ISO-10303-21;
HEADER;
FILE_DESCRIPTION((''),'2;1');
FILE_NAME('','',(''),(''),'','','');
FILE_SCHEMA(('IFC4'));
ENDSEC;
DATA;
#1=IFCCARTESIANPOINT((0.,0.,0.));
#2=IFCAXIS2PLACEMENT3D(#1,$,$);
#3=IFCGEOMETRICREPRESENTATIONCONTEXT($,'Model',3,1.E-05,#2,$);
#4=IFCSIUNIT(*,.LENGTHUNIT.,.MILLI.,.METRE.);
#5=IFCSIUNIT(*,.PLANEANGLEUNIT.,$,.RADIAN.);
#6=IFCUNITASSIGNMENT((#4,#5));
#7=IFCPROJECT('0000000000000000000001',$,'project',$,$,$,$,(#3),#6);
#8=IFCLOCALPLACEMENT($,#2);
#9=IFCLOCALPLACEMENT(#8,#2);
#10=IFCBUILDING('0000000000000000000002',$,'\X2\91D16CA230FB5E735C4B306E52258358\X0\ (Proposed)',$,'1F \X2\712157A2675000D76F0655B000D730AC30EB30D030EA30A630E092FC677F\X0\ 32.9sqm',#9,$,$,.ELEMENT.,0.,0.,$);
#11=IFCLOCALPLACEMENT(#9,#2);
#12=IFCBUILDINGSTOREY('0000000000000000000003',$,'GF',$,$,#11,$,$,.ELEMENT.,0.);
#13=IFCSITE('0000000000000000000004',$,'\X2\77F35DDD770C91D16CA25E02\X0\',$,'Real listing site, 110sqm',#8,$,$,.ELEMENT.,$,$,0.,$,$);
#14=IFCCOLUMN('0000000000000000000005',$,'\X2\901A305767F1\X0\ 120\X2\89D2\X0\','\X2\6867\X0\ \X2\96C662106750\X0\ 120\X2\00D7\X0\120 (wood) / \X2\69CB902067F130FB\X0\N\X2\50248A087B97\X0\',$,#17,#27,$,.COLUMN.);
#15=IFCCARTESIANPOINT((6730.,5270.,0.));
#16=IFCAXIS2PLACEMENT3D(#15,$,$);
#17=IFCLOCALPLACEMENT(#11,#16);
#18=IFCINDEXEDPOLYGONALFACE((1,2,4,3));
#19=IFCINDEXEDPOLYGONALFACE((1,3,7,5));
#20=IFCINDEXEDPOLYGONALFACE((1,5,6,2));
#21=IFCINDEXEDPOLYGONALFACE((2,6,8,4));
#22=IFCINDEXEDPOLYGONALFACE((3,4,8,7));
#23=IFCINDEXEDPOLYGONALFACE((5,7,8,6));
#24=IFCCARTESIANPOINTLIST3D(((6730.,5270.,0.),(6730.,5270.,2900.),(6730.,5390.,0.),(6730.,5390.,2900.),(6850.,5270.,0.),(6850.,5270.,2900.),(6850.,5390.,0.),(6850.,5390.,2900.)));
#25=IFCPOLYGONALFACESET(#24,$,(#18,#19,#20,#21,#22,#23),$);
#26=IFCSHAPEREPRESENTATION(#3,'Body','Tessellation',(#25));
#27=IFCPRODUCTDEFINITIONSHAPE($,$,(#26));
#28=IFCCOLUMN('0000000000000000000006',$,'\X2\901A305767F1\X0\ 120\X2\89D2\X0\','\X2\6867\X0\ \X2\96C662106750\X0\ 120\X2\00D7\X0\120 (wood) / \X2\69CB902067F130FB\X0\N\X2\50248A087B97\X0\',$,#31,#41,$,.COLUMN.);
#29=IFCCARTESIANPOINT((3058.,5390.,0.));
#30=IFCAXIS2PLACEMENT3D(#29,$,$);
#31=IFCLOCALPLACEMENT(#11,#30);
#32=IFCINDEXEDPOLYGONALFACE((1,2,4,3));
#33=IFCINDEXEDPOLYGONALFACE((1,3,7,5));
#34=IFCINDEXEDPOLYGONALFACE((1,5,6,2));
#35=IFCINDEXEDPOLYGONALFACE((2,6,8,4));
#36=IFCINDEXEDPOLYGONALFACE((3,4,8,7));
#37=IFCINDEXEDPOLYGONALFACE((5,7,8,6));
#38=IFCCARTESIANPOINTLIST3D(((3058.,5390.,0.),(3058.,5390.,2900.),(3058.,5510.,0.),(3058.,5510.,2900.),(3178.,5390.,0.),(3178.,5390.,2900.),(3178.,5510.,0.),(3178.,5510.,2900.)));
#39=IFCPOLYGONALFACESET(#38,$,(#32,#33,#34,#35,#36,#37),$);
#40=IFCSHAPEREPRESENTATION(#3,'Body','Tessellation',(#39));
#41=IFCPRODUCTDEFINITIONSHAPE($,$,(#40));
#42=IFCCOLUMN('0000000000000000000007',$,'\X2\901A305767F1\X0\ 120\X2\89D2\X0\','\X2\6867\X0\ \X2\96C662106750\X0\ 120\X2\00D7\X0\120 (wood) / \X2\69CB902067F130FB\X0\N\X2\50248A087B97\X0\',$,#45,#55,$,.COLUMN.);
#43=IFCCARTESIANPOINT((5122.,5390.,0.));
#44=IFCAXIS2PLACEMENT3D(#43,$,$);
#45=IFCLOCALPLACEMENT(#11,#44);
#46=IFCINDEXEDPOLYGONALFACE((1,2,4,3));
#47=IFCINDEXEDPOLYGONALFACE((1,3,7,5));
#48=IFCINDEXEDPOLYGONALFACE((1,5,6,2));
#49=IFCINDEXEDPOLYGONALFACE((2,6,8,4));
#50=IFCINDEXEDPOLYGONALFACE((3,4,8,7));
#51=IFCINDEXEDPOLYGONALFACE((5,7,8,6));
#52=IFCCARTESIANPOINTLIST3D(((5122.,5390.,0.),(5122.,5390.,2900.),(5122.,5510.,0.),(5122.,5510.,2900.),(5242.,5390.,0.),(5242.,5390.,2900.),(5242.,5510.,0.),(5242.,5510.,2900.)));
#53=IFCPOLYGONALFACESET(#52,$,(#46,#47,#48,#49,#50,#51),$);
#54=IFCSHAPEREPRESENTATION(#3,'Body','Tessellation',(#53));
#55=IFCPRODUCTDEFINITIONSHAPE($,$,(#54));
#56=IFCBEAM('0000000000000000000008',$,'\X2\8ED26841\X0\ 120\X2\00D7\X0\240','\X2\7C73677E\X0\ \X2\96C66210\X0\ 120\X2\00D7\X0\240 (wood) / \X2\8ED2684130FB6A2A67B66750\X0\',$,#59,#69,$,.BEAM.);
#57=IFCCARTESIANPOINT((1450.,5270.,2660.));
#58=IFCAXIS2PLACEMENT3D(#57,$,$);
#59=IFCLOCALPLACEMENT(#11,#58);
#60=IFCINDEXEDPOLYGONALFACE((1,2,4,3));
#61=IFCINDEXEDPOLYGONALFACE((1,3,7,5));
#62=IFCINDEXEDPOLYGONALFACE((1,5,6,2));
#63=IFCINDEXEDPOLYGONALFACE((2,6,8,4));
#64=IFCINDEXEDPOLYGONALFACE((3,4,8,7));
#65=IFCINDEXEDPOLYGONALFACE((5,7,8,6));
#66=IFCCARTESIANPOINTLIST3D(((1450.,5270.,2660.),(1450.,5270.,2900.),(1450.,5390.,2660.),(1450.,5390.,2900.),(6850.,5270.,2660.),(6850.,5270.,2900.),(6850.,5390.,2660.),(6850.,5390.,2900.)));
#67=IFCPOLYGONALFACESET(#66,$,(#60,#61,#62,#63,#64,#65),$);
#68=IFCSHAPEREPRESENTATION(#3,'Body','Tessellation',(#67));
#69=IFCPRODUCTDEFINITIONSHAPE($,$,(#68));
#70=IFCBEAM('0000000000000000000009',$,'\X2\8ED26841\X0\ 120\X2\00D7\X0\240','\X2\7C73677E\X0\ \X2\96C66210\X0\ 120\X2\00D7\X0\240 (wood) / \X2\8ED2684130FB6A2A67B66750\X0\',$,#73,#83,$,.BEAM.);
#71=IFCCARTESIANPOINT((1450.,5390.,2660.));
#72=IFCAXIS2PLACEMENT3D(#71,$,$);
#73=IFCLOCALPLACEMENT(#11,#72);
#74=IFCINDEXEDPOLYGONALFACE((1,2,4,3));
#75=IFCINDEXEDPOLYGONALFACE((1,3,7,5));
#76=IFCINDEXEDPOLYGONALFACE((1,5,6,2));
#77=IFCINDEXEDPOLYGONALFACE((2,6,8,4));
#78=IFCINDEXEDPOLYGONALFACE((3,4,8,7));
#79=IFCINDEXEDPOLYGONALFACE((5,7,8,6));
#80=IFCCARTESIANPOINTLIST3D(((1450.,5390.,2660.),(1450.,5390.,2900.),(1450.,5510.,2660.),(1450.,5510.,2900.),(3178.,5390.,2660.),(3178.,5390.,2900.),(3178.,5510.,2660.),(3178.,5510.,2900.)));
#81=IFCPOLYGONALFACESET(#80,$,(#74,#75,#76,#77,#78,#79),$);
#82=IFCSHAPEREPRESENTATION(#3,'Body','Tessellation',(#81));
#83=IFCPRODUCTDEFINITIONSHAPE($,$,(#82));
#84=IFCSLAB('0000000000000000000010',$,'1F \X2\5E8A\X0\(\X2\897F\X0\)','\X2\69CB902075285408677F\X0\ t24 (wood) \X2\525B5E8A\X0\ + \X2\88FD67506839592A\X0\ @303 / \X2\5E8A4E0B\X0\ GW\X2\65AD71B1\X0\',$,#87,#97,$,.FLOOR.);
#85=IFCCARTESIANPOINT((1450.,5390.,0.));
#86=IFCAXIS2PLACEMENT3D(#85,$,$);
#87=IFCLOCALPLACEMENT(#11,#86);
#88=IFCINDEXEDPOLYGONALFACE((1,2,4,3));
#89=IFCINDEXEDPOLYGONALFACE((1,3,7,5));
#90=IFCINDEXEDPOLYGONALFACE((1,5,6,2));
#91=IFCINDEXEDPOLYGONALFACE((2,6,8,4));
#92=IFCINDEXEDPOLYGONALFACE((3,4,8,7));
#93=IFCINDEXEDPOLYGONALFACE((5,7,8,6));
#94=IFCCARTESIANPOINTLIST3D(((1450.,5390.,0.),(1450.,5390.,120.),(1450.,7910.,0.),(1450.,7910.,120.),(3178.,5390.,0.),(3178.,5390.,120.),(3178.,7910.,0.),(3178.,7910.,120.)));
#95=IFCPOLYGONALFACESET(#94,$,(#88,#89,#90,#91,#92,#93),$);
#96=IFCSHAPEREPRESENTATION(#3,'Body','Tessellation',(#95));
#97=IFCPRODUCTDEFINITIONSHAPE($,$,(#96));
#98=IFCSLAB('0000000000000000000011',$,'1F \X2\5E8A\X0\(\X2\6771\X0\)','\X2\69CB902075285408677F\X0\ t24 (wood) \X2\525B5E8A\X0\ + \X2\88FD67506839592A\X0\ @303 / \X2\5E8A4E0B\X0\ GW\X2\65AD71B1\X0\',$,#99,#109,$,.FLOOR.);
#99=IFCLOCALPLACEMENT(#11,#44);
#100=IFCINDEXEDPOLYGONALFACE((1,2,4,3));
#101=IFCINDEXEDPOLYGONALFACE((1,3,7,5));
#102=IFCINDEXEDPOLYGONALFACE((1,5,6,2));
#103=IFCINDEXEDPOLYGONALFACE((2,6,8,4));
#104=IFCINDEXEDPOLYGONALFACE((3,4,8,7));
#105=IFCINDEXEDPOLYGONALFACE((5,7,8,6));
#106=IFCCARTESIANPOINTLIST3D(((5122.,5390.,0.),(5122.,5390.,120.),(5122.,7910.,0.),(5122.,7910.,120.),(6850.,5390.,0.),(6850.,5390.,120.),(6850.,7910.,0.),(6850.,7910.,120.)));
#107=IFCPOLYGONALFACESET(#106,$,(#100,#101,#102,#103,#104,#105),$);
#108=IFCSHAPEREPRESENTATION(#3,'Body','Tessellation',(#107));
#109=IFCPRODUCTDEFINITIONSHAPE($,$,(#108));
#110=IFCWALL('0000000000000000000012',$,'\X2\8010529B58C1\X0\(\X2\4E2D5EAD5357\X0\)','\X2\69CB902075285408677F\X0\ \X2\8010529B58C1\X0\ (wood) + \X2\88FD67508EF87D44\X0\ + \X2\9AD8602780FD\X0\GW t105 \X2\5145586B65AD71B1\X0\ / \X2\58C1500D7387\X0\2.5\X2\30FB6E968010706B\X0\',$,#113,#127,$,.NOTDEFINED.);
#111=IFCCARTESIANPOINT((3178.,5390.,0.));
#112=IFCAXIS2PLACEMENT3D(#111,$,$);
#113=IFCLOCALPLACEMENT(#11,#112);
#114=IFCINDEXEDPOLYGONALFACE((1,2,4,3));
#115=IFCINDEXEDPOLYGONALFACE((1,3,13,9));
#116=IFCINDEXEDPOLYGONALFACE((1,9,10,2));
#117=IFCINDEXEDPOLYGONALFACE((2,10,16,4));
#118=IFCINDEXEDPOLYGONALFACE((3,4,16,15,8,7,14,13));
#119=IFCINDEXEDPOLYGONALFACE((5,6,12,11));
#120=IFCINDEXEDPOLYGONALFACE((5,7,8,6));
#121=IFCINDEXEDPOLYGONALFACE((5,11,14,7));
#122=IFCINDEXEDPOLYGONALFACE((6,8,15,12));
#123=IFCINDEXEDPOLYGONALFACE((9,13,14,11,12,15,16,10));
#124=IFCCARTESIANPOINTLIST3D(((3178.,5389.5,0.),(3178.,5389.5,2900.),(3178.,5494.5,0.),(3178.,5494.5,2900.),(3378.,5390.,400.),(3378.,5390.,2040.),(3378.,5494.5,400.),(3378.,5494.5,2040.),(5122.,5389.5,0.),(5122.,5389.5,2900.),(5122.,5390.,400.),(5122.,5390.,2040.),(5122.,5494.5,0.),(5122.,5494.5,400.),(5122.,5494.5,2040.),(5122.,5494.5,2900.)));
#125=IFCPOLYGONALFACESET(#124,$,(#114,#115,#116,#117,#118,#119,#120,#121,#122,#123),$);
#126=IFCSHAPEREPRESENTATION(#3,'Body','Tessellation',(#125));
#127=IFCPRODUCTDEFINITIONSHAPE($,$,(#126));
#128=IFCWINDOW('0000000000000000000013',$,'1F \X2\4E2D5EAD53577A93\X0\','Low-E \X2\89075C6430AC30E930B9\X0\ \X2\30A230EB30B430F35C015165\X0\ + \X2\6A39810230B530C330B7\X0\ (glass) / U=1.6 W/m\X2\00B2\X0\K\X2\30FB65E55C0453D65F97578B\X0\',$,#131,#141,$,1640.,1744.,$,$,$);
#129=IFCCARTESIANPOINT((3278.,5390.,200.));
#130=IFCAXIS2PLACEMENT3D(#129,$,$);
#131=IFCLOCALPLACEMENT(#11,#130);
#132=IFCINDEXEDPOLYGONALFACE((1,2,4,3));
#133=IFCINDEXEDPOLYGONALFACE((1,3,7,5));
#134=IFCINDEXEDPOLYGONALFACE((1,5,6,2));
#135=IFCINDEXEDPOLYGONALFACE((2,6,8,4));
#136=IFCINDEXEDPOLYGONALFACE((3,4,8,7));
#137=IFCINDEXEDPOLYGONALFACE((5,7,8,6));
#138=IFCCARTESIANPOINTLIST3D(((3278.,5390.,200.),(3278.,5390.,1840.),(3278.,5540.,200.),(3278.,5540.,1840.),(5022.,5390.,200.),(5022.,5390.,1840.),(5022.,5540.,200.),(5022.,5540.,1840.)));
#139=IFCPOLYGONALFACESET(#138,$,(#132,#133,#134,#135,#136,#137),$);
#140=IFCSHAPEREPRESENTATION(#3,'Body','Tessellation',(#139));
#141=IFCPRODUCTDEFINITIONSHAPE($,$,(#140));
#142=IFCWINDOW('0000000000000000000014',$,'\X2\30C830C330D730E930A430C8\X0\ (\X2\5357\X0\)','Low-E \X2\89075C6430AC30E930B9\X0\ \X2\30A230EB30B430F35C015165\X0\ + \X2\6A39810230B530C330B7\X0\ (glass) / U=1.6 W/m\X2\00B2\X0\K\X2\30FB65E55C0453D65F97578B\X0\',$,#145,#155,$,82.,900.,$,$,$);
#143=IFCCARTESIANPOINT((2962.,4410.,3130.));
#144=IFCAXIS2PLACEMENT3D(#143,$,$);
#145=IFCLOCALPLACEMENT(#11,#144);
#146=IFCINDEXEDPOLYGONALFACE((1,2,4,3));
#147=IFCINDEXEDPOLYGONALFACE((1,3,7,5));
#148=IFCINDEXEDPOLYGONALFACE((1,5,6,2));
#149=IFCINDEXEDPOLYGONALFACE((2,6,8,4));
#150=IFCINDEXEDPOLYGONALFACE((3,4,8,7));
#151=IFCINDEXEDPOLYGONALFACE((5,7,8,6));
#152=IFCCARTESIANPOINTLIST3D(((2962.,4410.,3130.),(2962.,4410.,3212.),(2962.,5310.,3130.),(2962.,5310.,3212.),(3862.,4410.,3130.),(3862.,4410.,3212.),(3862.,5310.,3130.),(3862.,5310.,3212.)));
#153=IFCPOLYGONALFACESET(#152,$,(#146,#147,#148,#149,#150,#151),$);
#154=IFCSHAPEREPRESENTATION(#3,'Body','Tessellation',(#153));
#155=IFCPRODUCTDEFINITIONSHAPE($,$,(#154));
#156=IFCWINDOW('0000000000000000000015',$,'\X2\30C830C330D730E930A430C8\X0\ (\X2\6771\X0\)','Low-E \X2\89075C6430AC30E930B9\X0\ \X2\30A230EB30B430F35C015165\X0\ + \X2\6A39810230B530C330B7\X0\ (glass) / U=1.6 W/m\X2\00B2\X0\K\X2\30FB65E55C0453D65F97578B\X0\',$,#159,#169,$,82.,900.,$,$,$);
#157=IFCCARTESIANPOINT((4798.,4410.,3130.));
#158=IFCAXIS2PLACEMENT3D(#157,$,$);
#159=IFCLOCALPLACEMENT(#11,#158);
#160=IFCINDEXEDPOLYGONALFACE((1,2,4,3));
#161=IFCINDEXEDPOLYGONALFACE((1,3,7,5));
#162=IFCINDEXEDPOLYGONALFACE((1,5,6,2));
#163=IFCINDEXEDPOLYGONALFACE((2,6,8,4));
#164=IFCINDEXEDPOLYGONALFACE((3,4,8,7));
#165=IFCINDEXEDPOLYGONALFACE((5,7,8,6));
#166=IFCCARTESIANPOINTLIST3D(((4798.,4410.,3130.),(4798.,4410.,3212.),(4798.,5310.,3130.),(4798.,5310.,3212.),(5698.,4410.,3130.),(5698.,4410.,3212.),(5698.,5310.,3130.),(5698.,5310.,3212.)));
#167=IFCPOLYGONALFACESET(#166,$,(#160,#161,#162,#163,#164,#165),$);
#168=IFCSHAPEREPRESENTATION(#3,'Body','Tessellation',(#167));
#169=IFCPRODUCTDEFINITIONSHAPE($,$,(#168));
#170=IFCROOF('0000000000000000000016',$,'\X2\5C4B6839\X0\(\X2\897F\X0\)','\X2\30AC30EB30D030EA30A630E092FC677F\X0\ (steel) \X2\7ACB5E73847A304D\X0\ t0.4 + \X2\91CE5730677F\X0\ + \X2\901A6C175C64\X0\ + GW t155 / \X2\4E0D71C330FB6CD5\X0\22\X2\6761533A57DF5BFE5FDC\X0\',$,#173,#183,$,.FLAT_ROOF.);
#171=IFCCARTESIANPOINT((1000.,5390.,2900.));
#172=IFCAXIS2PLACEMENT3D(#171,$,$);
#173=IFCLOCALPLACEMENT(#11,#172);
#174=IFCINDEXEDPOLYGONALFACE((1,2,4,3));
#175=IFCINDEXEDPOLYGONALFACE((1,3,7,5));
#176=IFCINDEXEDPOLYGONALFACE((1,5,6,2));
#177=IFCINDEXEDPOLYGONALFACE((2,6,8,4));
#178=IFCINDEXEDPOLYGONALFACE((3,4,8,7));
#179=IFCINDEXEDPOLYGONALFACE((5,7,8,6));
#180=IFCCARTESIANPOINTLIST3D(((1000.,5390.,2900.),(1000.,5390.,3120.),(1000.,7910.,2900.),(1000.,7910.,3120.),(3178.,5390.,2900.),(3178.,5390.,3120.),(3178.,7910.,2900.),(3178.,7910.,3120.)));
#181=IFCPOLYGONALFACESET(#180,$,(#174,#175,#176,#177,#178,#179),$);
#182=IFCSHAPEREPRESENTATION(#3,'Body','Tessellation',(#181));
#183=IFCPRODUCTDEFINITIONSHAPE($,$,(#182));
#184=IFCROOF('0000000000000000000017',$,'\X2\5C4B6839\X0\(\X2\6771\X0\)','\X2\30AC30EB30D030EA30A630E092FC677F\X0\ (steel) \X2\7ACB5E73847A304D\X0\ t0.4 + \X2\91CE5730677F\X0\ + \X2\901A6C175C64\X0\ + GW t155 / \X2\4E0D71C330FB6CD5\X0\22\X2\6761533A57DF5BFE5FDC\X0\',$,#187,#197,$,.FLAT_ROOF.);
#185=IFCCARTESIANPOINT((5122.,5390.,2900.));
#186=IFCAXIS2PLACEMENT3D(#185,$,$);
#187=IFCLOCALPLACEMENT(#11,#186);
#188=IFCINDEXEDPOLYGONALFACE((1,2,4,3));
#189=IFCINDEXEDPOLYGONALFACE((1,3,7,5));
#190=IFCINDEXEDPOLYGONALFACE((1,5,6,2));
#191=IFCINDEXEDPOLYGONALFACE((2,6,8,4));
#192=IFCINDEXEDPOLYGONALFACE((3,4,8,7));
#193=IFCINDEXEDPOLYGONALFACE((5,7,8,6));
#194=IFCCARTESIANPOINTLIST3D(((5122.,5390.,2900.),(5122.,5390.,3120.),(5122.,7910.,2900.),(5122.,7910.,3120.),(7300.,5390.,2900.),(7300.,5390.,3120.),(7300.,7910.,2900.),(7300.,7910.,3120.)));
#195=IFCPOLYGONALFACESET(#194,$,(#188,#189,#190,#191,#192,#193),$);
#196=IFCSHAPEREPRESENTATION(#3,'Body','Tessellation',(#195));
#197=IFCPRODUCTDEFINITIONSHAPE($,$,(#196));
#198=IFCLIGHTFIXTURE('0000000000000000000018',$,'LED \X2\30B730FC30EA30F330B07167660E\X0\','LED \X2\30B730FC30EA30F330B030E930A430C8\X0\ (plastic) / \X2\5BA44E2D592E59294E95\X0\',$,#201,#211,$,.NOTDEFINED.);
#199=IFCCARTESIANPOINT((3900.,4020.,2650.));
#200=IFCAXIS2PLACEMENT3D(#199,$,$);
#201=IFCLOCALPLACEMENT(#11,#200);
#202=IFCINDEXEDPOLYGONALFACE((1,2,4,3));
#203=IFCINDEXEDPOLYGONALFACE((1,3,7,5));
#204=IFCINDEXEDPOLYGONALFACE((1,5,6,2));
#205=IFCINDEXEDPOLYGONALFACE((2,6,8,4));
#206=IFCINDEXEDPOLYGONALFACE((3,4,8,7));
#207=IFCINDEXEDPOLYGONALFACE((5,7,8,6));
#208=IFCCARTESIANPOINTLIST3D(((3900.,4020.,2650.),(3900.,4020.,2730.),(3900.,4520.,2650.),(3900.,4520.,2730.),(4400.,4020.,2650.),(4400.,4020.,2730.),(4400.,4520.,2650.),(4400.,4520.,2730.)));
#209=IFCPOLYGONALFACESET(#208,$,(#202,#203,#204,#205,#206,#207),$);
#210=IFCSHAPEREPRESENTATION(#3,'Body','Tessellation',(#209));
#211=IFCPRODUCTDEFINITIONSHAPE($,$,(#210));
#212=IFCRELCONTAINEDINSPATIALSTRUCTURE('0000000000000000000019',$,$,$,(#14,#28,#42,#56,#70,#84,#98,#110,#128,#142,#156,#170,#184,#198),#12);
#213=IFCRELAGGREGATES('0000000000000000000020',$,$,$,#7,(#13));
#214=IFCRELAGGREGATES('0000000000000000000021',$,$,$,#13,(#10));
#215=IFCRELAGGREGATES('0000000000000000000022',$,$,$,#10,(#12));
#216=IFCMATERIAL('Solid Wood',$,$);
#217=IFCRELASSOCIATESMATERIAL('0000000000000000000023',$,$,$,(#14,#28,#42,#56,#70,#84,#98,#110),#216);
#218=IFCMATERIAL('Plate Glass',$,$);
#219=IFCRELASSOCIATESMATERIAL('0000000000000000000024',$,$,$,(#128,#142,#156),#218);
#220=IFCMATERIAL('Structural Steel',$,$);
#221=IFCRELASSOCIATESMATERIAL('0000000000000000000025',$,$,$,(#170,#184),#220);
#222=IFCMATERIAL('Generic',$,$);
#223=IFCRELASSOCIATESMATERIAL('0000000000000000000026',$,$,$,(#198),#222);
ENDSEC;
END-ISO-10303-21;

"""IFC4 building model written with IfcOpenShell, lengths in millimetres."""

from ifc_helpers import new_model, si_unit, frame, frame_2d, origin, place, context, project, spatial, rectangle, extrude, material, element, fill, save


model = new_model("IFC4")

# Units and contexts
model_context = context("Model", 3, precision=1e-05, world=origin())
ifc_project = project(units=[si_unit("LENGTHUNIT", "METRE", prefix="MILLI"), si_unit("PLANEANGLEUNIT", "RADIAN")], contexts=[model_context])

# Site, building, storey
site_placement = place(None, origin())
site = spatial("IfcSite", under=ifc_project, at=site_placement, Name="石川県金沢市", ObjectType="Real listing site, 110sqm", CompositionType="ELEMENT", RefElevation=0.0)
building_placement = place(site_placement, origin())
building = spatial("IfcBuilding", under=site, at=building_placement, Name="金沢・平屋の別荘 (Proposed)", ObjectType="1F 無垢材×漆喰×ガルバリウム鋼板 32.9sqm", CompositionType="ELEMENT", ElevationOfRefHeight=0.0, ElevationOfTerrain=0.0)
storey_placement = place(building_placement, origin())
storey = spatial("IfcBuildingStorey", under=building, at=storey_placement, Name="GF", CompositionType="ELEMENT", Elevation=0.0)

# Columns
ifc_material_1 = material(Name="Solid Wood")
column_1_placement = place(storey_placement, frame((6730.0, 5270.0, 0.0)))
element("IfcColumn", 1, at=column_1_placement, inside=storey, material=ifc_material_1, Name="通し柱 120角", Description="桧 集成材 120×120 (wood) / 構造柱・N値計算", PredefinedType="COLUMN", context=model_context, shape_type="SweptSolid", body=[
    extrude(rectangle(XDim=120.0, YDim=120.0, at=frame_2d((60.0, 60.0))), frame((6730.0, 5270.0, 0.0)), (0.0, 0.0, 1.0), 2900.0),
])
column_2_placement = place(storey_placement, frame((3058.0, 5390.0, 0.0)))
element("IfcColumn", 2, at=column_2_placement, inside=storey, material=ifc_material_1, Name="通し柱 120角", Description="桧 集成材 120×120 (wood) / 構造柱・N値計算", PredefinedType="COLUMN", context=model_context, shape_type="SweptSolid", body=[
    extrude(rectangle(XDim=120.0, YDim=120.0, at=frame_2d((60.0, 60.0))), frame((3058.0, 5390.0, 0.0)), (0.0, 0.0, 1.0), 2900.0),
])
column_3_placement = place(storey_placement, frame((5122.0, 5390.0, 0.0)))
element("IfcColumn", 3, at=column_3_placement, inside=storey, material=ifc_material_1, Name="通し柱 120角", Description="桧 集成材 120×120 (wood) / 構造柱・N値計算", PredefinedType="COLUMN", context=model_context, shape_type="SweptSolid", body=[
    extrude(rectangle(XDim=120.0, YDim=120.0, at=frame_2d((60.0, 60.0))), frame((5122.0, 5390.0, 0.0)), (0.0, 0.0, 1.0), 2900.0),
])

# Beams
beam_1_placement = place(storey_placement, frame((1450.0, 5270.0, 2660.0)))
element("IfcBeam", 4, at=beam_1_placement, inside=storey, material=ifc_material_1, Name="軒桁 120×240", Description="米松 集成 120×240 (wood) / 軒桁・横架材", PredefinedType="BEAM", context=model_context, shape_type="SweptSolid", body=[
    extrude(rectangle(XDim=5400.0, YDim=120.0, at=frame_2d((2700.0, 60.0))), frame((1450.0, 5270.0, 2660.0)), (0.0, 0.0, 1.0), 240.0),
])
beam_2_placement = place(storey_placement, frame((1450.0, 5390.0, 2660.0)))
element("IfcBeam", 5, at=beam_2_placement, inside=storey, material=ifc_material_1, Name="軒桁 120×240", Description="米松 集成 120×240 (wood) / 軒桁・横架材", PredefinedType="BEAM", context=model_context, shape_type="SweptSolid", body=[
    extrude(rectangle(XDim=1728.0, YDim=120.0, at=frame_2d((864.0, 60.0))), frame((1450.0, 5390.0, 2660.0)), (0.0, 0.0, 1.0), 240.0),
])

# Slabs
slab_1_placement = place(storey_placement, frame((1450.0, 5390.0, 0.0)))
element("IfcSlab", 6, at=slab_1_placement, inside=storey, material=ifc_material_1, Name="1F 床(西)", Description="構造用合板 t24 (wood) 剛床 + 製材根太 @303 / 床下 GW断熱", PredefinedType="FLOOR", context=model_context, shape_type="SweptSolid", body=[
    extrude(rectangle(XDim=1728.0, YDim=2520.0, at=frame_2d((864.0, 1260.0))), frame((1450.0, 5390.0, 0.0)), (0.0, 0.0, 1.0), 120.0),
])
slab_2_placement = place(storey_placement, frame((5122.0, 5390.0, 0.0)))
element("IfcSlab", 7, at=slab_2_placement, inside=storey, material=ifc_material_1, Name="1F 床(東)", Description="構造用合板 t24 (wood) 剛床 + 製材根太 @303 / 床下 GW断熱", PredefinedType="FLOOR", context=model_context, shape_type="SweptSolid", body=[
    extrude(rectangle(XDim=1728.0, YDim=2520.0, at=frame_2d((864.0, 1260.0))), frame((5122.0, 5390.0, 0.0)), (0.0, 0.0, 1.0), 120.0),
])

# Wall, opening, window
wall_1_placement = place(storey_placement, frame((3178.0, 5390.0, 0.0)))
wall_1 = element("IfcWall", 8, at=wall_1_placement, inside=storey, material=ifc_material_1, Name="耐力壁(中庭南)", Description="構造用合板 耐力壁 (wood) + 製材軸組 + 高性能GW t105 充填断熱 / 壁倍率2.5・準耐火", PredefinedType="NOTDEFINED", context=model_context, shape_type="SweptSolid", body=[
    extrude(rectangle(XDim=1944.0, YDim=105.0, at=frame_2d((972.0, 52.0))), frame((3178.0, 5390.0, 0.0)), (0.0, 0.0, 1.0), 2900.0),
])
opening_placement = place(storey_placement, frame((3278.0, 5390.0, 200.0)))
opening = element("IfcOpeningElement", 9, at=opening_placement, cuts=wall_1, PredefinedType="NOTDEFINED", context=model_context, shape_type="SweptSolid", body=[
    extrude(rectangle(XDim=1744.0, YDim=150.0, at=frame_2d((872.0, 75.0))), frame((3278.0, 5390.0, 200.0)), (0.0, 0.0, 1.0), 1640.0),
])
ifc_material_2 = material(Name="Plate Glass")
window_1_placement = place(storey_placement, frame((3278.0, 5390.0, 200.0)))
window_1 = element("IfcWindow", 10, at=window_1_placement, inside=storey, material=ifc_material_2, Name="1F 中庭南窓", Description="Low-E 複層ガラス アルゴン封入 + 樹脂サッシ (glass) / U=1.6 W/m²K・日射取得型", OverallHeight=1640.0, OverallWidth=1744.0, context=model_context, shape_type="SweptSolid", body=[
    extrude(rectangle(XDim=1744.0, YDim=150.0, at=frame_2d((872.0, 75.0))), frame((3278.0, 5390.0, 200.0)), (0.0, 0.0, 1.0), 1640.0),
])
fill(opening, window_1)

# Windows
window_2_placement = place(storey_placement, frame((2962.0, 4410.0, 3130.0)))
element("IfcWindow", 11, at=window_2_placement, inside=storey, material=ifc_material_2, Name="トップライト (南)", Description="Low-E 複層ガラス アルゴン封入 + 樹脂サッシ (glass) / U=1.6 W/m²K・日射取得型", OverallHeight=82.0, OverallWidth=900.0, context=model_context, shape_type="SweptSolid", body=[
    extrude(rectangle(XDim=900.0, YDim=900.0, at=frame_2d((450.0, 450.0))), frame((2962.0, 4410.0, 3130.0)), (0.0, 0.0, 1.0), 82.0),
])
window_3_placement = place(storey_placement, frame((4798.0, 4410.0, 3130.0)))
element("IfcWindow", 12, at=window_3_placement, inside=storey, material=ifc_material_2, Name="トップライト (東)", Description="Low-E 複層ガラス アルゴン封入 + 樹脂サッシ (glass) / U=1.6 W/m²K・日射取得型", OverallHeight=82.0, OverallWidth=900.0, context=model_context, shape_type="SweptSolid", body=[
    extrude(rectangle(XDim=900.0, YDim=900.0, at=frame_2d((450.0, 450.0))), frame((4798.0, 4410.0, 3130.0)), (0.0, 0.0, 1.0), 82.0),
])

# Roofs
ifc_material_3 = material(Name="Structural Steel")
roof_1_placement = place(storey_placement, frame((1000.0, 5390.0, 2900.0)))
element("IfcRoof", 13, at=roof_1_placement, inside=storey, material=ifc_material_3, Name="屋根(西)", Description="ガルバリウム鋼板 (steel) 立平葺き t0.4 + 野地板 + 通気層 + GW t155 / 不燃・法22条区域対応", PredefinedType="FLAT_ROOF", context=model_context, shape_type="SweptSolid", body=[
    extrude(rectangle(XDim=2178.0, YDim=2520.0, at=frame_2d((1089.0, 1260.0))), frame((1000.0, 5390.0, 2900.0)), (0.0, 0.0, 1.0), 220.0),
])
roof_2_placement = place(storey_placement, frame((5122.0, 5390.0, 2900.0)))
element("IfcRoof", 14, at=roof_2_placement, inside=storey, material=ifc_material_3, Name="屋根(東)", Description="ガルバリウム鋼板 (steel) 立平葺き t0.4 + 野地板 + 通気層 + GW t155 / 不燃・法22条区域対応", PredefinedType="FLAT_ROOF", context=model_context, shape_type="SweptSolid", body=[
    extrude(rectangle(XDim=2178.0, YDim=2520.0, at=frame_2d((1089.0, 1260.0))), frame((5122.0, 5390.0, 2900.0)), (0.0, 0.0, 1.0), 220.0),
])

# Light fixture
ifc_material_4 = material(Name="Generic")
light_fixture_placement = place(storey_placement, frame((3900.0, 4020.0, 2650.0)))
element("IfcLightFixture", 15, at=light_fixture_placement, inside=storey, material=ifc_material_4, Name="LED シーリング照明", Description="LED シーリングライト (plastic) / 室中央天井", PredefinedType="NOTDEFINED", context=model_context, shape_type="SweptSolid", body=[
    extrude(rectangle(XDim=500.0, YDim=500.0, at=frame_2d((250.0, 250.0))), frame((3900.0, 4020.0, 2650.0)), (0.0, 0.0, 1.0), 80.0),
])

save(model, "model.ifc")
